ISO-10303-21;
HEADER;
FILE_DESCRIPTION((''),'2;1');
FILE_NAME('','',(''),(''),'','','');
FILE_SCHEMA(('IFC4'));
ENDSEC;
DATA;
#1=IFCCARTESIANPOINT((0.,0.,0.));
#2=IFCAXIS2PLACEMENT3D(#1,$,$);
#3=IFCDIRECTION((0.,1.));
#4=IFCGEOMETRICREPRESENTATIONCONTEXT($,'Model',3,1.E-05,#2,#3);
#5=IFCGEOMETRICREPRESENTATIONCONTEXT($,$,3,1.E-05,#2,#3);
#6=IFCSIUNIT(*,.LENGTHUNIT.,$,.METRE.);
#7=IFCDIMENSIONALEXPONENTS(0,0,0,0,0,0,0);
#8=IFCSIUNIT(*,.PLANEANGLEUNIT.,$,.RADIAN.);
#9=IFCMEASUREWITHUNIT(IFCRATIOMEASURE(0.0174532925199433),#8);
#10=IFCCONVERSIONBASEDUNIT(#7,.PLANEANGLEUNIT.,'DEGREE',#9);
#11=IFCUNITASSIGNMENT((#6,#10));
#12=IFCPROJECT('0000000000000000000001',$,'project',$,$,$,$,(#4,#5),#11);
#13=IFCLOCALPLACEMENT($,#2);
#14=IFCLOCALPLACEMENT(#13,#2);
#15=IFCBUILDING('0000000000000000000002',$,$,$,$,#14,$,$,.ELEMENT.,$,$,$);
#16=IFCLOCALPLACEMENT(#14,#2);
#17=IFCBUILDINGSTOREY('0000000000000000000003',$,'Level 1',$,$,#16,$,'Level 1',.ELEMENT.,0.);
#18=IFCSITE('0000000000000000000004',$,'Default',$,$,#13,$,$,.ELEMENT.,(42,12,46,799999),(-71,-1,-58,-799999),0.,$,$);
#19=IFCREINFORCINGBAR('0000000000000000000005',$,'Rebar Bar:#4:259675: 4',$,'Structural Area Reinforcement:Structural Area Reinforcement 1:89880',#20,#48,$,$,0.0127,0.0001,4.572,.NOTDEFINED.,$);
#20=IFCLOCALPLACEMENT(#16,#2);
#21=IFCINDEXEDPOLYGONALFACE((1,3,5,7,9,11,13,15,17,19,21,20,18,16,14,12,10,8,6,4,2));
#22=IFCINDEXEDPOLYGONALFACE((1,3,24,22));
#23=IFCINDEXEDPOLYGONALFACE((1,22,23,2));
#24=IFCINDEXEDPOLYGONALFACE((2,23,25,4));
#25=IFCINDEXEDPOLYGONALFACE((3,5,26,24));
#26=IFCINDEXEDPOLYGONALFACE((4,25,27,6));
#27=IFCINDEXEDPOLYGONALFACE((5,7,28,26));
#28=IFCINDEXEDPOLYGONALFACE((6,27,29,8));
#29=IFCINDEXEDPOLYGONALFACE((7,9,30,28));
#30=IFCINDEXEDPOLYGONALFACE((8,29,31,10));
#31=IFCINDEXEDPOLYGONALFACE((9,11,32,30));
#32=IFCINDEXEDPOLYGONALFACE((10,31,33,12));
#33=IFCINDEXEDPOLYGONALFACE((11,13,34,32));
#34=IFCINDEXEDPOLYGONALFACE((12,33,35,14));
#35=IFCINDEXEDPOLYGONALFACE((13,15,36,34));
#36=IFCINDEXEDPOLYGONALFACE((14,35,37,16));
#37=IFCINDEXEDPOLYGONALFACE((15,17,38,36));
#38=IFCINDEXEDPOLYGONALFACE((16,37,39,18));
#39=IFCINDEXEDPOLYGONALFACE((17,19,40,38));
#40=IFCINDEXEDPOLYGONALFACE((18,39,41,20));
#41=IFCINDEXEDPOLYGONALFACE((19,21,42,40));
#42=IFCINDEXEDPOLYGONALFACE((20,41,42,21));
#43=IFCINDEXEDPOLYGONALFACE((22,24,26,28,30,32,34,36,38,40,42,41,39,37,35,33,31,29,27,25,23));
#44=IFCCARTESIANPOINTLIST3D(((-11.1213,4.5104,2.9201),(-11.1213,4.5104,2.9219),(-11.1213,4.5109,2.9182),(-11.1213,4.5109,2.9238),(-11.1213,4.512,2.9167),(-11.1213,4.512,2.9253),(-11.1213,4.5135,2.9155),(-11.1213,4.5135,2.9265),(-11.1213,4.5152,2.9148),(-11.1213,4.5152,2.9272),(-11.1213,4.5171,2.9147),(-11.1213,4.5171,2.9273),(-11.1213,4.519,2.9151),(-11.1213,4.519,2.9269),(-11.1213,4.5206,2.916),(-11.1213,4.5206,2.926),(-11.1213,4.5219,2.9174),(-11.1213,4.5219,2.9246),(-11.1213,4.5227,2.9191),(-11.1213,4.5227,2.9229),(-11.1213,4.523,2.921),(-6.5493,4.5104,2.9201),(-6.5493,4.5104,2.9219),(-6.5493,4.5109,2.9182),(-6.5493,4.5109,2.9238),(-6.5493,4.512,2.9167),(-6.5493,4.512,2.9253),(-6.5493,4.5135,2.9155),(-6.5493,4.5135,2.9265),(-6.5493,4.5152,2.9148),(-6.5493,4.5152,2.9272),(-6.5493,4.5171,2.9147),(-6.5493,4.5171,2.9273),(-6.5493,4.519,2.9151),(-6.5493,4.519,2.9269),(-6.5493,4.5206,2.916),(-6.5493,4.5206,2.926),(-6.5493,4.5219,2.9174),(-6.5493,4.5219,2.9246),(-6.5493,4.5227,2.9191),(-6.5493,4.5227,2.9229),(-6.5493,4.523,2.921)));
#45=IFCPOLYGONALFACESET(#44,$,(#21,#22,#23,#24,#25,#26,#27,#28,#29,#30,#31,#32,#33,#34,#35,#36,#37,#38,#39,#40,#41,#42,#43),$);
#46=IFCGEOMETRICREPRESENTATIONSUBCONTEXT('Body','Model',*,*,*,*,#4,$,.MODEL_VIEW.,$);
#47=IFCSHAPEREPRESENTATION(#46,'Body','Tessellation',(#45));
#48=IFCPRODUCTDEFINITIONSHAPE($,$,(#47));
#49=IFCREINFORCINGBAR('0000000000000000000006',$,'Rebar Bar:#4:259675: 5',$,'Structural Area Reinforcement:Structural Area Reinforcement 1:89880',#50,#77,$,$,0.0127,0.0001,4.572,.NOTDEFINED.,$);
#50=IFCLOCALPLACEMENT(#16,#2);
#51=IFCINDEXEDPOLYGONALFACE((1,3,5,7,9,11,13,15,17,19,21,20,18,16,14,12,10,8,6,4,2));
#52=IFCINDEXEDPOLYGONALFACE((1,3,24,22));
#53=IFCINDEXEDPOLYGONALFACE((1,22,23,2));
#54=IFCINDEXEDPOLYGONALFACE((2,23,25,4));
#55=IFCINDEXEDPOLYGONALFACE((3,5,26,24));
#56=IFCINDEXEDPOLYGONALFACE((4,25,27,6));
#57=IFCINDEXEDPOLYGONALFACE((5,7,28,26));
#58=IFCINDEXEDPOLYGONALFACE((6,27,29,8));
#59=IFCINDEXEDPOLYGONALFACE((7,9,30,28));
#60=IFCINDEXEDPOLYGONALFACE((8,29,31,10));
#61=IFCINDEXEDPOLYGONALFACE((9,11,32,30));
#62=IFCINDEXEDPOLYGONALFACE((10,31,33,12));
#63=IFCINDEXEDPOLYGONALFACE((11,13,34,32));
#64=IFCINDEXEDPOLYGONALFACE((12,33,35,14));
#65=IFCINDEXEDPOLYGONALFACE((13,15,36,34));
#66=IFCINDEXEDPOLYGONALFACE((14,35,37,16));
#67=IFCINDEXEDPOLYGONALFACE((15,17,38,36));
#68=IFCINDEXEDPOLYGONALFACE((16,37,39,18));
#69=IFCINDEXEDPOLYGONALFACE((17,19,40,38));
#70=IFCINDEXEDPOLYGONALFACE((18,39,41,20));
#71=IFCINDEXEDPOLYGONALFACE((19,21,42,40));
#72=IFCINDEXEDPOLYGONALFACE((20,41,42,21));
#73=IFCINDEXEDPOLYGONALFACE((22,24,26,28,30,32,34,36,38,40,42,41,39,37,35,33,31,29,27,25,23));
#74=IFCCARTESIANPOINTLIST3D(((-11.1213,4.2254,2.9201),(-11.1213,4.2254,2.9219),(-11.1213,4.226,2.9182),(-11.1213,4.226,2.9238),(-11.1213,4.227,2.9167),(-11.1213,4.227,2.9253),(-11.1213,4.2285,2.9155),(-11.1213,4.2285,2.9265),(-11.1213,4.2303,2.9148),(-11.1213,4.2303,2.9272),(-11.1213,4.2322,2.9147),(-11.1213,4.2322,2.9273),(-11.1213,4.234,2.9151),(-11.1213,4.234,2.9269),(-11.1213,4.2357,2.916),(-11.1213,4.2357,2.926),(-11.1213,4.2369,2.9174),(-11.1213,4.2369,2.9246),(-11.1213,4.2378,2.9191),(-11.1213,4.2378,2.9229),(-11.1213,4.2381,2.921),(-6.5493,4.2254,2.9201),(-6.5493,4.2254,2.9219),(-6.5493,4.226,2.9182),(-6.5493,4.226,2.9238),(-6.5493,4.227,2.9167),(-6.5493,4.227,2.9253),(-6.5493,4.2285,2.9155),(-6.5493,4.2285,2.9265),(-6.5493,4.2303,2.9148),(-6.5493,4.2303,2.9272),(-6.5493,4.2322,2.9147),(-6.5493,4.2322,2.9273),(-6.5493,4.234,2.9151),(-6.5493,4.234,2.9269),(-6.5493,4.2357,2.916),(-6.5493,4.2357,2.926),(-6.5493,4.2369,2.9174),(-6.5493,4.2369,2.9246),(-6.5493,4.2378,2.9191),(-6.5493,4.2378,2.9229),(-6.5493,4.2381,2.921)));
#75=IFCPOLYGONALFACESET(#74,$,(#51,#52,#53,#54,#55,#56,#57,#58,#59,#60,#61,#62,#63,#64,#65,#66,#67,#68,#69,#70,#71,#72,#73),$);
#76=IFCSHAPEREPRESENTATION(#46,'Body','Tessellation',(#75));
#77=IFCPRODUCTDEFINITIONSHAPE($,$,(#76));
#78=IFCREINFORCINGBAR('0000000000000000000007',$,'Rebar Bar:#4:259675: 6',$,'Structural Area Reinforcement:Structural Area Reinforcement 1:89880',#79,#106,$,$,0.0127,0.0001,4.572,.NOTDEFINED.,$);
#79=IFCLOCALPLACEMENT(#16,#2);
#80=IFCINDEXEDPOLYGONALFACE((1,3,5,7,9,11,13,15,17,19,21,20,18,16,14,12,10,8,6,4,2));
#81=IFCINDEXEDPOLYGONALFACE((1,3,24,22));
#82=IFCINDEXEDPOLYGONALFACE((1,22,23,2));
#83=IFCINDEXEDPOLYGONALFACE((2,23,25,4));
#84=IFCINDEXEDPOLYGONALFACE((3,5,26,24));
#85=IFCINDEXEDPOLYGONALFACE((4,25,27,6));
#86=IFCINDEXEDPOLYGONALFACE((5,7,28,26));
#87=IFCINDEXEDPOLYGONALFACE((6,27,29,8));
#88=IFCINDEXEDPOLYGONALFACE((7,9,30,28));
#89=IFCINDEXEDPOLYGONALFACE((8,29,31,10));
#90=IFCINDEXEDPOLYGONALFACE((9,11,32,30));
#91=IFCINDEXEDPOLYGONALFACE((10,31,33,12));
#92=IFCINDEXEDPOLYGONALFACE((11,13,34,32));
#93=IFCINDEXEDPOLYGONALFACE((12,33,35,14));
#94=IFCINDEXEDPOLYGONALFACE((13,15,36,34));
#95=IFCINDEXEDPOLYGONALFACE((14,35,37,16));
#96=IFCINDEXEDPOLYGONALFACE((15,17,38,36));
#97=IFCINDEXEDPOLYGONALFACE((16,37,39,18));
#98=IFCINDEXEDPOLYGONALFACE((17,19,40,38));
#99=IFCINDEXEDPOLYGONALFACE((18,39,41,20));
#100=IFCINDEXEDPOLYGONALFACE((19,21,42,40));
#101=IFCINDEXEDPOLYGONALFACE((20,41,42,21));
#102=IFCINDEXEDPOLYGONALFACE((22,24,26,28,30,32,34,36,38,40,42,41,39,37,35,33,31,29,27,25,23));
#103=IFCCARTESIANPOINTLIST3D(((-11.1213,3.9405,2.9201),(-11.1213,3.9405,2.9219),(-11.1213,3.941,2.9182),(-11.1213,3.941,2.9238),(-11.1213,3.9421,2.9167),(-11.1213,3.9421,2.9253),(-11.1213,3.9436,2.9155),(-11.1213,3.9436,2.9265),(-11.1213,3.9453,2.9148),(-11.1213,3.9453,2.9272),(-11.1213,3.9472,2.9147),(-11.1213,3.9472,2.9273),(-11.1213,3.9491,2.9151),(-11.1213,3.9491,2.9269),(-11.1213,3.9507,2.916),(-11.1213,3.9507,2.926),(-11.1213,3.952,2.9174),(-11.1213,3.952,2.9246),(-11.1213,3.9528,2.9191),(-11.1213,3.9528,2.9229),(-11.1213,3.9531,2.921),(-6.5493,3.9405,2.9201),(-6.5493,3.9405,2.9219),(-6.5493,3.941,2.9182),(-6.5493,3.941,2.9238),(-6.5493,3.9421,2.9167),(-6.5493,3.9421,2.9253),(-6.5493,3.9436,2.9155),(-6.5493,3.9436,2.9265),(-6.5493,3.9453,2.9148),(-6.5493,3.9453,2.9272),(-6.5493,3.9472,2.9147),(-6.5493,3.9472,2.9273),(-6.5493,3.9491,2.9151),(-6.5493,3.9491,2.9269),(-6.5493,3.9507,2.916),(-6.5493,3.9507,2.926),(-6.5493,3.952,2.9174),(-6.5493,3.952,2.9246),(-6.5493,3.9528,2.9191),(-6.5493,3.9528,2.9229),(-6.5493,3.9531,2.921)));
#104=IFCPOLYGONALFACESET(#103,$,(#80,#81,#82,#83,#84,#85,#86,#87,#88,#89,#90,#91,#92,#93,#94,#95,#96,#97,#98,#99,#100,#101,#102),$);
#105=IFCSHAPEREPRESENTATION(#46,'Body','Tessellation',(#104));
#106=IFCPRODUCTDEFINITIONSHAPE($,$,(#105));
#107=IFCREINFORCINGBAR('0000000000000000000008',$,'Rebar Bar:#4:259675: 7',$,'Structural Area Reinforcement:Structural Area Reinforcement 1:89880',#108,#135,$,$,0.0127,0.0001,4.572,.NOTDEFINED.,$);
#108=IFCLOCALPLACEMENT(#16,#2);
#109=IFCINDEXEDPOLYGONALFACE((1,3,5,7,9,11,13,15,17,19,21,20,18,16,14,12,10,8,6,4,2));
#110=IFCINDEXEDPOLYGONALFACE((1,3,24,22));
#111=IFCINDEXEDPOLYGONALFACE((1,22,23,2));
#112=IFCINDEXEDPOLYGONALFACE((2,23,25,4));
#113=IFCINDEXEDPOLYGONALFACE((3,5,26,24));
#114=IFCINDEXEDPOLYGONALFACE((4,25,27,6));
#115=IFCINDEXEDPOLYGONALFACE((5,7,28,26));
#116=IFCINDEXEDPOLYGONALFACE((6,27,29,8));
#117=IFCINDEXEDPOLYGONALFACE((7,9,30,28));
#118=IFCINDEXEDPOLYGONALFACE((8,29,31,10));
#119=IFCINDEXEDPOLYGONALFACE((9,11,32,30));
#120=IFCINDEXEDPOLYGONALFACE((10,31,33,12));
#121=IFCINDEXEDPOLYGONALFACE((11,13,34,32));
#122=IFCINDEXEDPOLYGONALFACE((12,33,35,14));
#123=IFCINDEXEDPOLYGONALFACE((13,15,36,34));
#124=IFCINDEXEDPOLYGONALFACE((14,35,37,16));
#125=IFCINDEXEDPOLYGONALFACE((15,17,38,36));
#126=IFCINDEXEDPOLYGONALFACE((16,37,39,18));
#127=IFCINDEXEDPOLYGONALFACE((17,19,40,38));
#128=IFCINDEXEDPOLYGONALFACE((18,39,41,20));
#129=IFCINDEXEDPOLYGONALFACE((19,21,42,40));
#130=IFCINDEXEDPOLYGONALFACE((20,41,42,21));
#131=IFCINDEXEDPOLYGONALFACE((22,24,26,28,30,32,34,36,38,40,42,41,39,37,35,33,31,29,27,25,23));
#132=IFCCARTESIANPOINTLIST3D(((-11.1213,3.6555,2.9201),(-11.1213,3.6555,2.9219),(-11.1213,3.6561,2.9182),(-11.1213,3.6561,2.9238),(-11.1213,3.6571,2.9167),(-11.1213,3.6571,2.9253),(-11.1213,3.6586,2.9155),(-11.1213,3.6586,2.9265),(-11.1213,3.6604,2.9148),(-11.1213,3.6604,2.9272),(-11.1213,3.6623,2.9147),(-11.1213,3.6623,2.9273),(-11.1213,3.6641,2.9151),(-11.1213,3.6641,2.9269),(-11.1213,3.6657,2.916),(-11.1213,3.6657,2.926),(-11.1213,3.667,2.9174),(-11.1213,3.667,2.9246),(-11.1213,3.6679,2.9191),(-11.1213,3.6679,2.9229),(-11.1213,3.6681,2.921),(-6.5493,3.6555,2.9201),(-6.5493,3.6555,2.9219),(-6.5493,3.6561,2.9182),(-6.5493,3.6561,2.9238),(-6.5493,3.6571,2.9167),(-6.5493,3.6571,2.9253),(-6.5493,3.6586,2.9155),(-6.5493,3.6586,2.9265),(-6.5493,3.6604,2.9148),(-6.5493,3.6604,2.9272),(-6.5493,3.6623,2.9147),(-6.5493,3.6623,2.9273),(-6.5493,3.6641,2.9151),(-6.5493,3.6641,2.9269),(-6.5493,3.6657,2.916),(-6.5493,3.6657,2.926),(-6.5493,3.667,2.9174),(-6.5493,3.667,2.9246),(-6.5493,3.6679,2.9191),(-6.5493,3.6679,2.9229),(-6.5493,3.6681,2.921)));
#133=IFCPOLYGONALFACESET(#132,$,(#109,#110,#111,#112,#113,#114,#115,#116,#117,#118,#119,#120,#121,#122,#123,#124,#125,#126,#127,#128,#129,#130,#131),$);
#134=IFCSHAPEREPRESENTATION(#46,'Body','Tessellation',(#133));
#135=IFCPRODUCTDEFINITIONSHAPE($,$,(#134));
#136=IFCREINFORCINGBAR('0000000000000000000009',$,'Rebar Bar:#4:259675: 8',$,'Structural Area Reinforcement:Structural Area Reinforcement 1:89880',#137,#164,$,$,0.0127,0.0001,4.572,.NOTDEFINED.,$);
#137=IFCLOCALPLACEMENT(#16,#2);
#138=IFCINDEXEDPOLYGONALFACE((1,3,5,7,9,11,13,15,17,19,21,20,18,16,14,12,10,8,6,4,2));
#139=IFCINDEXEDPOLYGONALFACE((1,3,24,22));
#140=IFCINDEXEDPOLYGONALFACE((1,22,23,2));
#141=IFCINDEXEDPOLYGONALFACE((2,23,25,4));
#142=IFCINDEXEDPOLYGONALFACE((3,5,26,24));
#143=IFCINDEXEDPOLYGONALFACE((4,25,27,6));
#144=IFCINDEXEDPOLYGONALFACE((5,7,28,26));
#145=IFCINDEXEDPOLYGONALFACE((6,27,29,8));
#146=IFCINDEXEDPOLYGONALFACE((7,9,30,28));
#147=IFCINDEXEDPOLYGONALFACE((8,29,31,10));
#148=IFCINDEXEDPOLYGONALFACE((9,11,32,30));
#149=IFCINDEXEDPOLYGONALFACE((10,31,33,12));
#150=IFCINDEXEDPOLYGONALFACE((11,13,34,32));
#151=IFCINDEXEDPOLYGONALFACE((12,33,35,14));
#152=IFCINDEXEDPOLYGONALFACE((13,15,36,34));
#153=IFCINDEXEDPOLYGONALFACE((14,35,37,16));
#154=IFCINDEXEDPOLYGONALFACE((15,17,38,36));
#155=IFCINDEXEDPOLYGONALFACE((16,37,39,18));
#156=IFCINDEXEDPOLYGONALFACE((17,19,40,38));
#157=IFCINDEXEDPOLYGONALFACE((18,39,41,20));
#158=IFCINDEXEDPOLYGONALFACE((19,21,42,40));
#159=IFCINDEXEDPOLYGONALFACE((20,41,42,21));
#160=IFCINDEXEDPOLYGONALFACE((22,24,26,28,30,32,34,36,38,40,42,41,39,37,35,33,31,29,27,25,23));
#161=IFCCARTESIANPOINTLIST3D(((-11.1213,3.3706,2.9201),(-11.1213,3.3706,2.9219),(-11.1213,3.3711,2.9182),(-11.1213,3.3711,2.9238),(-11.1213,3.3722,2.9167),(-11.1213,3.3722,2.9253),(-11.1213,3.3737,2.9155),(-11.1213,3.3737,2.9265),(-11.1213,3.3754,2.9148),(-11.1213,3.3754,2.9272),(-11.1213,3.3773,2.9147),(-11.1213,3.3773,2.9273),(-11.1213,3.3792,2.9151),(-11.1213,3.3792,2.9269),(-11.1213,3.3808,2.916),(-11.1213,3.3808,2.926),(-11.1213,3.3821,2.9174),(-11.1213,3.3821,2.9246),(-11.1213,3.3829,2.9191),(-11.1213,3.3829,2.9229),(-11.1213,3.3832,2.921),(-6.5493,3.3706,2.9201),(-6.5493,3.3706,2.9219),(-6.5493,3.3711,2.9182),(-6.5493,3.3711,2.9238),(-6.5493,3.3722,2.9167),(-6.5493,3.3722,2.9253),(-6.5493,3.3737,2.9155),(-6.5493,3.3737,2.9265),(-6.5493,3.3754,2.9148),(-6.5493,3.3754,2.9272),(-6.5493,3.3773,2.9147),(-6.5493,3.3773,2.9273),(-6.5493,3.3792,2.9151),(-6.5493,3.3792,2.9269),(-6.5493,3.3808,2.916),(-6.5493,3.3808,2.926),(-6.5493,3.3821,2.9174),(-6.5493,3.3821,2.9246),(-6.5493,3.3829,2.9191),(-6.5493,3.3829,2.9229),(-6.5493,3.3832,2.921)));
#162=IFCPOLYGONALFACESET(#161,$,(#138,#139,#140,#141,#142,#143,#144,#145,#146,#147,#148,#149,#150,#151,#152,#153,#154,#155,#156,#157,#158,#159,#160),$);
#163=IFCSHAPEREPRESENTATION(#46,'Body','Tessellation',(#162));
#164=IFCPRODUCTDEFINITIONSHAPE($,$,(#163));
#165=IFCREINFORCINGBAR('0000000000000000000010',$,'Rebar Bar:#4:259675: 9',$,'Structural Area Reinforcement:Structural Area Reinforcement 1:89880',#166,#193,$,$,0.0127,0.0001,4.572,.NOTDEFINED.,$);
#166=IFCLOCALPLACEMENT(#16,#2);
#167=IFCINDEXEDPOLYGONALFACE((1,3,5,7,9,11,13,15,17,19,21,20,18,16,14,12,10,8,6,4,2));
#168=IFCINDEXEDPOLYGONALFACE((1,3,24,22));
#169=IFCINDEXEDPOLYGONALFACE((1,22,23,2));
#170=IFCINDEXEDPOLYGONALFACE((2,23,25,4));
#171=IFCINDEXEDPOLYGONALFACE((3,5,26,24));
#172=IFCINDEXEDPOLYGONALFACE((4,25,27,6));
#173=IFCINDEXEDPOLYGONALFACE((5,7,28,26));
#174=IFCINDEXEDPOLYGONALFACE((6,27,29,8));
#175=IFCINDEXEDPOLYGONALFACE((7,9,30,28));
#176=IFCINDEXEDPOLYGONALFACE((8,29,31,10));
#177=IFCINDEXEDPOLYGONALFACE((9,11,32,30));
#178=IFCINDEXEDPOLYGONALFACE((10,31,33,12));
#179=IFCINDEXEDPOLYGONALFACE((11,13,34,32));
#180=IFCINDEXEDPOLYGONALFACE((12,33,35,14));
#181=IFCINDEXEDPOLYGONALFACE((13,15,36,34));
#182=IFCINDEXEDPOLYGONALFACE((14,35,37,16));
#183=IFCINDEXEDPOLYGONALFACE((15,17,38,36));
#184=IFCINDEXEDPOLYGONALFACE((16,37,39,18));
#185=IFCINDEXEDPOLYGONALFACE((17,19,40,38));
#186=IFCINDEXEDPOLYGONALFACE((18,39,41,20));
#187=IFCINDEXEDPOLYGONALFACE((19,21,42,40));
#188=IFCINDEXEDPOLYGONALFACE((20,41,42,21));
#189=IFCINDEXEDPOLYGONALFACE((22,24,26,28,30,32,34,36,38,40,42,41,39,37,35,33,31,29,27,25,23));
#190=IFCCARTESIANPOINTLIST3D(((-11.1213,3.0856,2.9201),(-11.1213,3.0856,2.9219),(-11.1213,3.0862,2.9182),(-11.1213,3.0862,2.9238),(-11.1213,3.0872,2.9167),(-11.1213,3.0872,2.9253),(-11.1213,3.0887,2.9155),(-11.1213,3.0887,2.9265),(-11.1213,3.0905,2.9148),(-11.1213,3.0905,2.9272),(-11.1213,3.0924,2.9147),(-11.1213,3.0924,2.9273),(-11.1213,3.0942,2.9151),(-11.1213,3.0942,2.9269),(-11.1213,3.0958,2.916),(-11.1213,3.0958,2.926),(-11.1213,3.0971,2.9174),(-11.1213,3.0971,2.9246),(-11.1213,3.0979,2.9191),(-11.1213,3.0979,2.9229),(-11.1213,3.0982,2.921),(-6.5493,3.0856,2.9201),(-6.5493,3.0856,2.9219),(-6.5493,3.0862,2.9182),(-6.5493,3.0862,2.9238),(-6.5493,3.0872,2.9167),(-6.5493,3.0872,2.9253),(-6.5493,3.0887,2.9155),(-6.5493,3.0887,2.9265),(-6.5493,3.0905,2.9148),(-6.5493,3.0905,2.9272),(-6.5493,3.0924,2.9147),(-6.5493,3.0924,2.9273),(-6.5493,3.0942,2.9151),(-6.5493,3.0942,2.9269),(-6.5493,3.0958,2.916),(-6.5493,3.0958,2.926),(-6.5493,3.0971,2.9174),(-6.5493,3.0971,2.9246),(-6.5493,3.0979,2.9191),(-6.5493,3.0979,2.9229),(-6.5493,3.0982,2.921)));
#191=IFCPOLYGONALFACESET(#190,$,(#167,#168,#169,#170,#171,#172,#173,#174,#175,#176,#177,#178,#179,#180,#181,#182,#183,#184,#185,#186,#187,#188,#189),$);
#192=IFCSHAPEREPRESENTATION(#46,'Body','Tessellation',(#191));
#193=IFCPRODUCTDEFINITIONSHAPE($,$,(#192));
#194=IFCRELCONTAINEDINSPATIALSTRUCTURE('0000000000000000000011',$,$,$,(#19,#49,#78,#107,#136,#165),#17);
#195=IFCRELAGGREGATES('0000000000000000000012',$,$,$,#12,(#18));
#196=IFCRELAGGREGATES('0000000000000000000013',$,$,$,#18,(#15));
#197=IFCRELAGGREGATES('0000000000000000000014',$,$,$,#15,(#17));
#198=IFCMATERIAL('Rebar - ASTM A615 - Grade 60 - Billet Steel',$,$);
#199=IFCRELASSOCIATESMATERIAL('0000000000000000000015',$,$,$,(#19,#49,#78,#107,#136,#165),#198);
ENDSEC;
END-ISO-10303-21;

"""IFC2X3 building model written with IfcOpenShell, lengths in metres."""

from ifc_helpers import new_model, entity, si_unit, converted_unit, direction, origin, place, context, subcontext, project, spatial, material, element, save


model = new_model("IFC2X3")

# Units and contexts
model_context = context("Model", 3, precision=1e-05, world=origin(), true_north=direction((0.0, 1.0)))
context_of_model = context(None, 3, precision=1e-05, world=origin(), true_north=direction((0.0, 1.0)))
body_context = subcontext(model_context, "Body", "Model", "MODEL_VIEW")
ifc_project = project(units=[si_unit("LENGTHUNIT", "METRE"), converted_unit("PLANEANGLEUNIT", "DEGREE", entity("IfcRatioMeasure", 0.0174532925199433), si_unit("PLANEANGLEUNIT", "RADIAN"), dimensions=[0, 0, 0, 0, 0, 0, 0])], contexts=[model_context, context_of_model])

# Site, building, storey
site_placement = place(None, origin())
site = spatial("IfcSite", under=ifc_project, at=site_placement, Name="Default", CompositionType="ELEMENT", RefLatitude=(42, 12, 46, 799999), RefLongitude=(-71, -1, -58, -799999), RefElevation=0.0)
building_placement = place(site_placement, origin())
building = spatial("IfcBuilding", under=site, at=building_placement, CompositionType="ELEMENT")
storey_placement = place(building_placement, origin())
storey = spatial("IfcBuildingStorey", under=building, at=storey_placement, Name="Level 1", LongName="Level 1", CompositionType="ELEMENT", Elevation=0.0)

# Reinforcing bars
ifc_material_1 = material(Name="Rebar - ASTM A615 - Grade 60 - Billet Steel")
reinforcing_bar_1_placement = place(storey_placement, origin())
element("IfcReinforcingBar", 1, at=reinforcing_bar_1_placement, inside=storey, material=ifc_material_1, Name="Rebar Bar:#4:259675: 4", ObjectType="Structural Area Reinforcement:Structural Area Reinforcement 1:89880", BarLength=4.572, BarRole="NOTDEFINED", CrossSectionArea=0.0001, NominalDiameter=0.0127, context=body_context, shape_type="AdvancedSweptSolid", body=[
    entity("IfcSweptDiskSolid", entity("IfcCompositeCurve", [entity("IfcCompositeCurveSegment", "CONTINUOUS", True, entity("IfcPolyline", [entity("IfcCartesianPoint", [-11.1213, 4.5167, 2.921]), entity("IfcCartesianPoint", [-6.5493, 4.5167, 2.921])]))], False), 0.0063, None, 0.0, 1.0),
])
reinforcing_bar_2_placement = place(storey_placement, origin())
element("IfcReinforcingBar", 2, at=reinforcing_bar_2_placement, inside=storey, material=ifc_material_1, Name="Rebar Bar:#4:259675: 5", ObjectType="Structural Area Reinforcement:Structural Area Reinforcement 1:89880", BarLength=4.572, BarRole="NOTDEFINED", CrossSectionArea=0.0001, NominalDiameter=0.0127, context=body_context, shape_type="AdvancedSweptSolid", body=[
    entity("IfcSweptDiskSolid", entity("IfcCompositeCurve", [entity("IfcCompositeCurveSegment", "CONTINUOUS", True, entity("IfcPolyline", [entity("IfcCartesianPoint", [-11.1213, 4.2317, 2.921]), entity("IfcCartesianPoint", [-6.5493, 4.2317, 2.921])]))], False), 0.0063, None, 0.0, 1.0),
])
reinforcing_bar_3_placement = place(storey_placement, origin())
element("IfcReinforcingBar", 3, at=reinforcing_bar_3_placement, inside=storey, material=ifc_material_1, Name="Rebar Bar:#4:259675: 6", ObjectType="Structural Area Reinforcement:Structural Area Reinforcement 1:89880", BarLength=4.572, BarRole="NOTDEFINED", CrossSectionArea=0.0001, NominalDiameter=0.0127, context=body_context, shape_type="AdvancedSweptSolid", body=[
    entity("IfcSweptDiskSolid", entity("IfcCompositeCurve", [entity("IfcCompositeCurveSegment", "CONTINUOUS", True, entity("IfcPolyline", [entity("IfcCartesianPoint", [-11.1213, 3.9467, 2.921]), entity("IfcCartesianPoint", [-6.5493, 3.9467, 2.921])]))], False), 0.0063, None, 0.0, 1.0),
])
reinforcing_bar_4_placement = place(storey_placement, origin())
element("IfcReinforcingBar", 4, at=reinforcing_bar_4_placement, inside=storey, material=ifc_material_1, Name="Rebar Bar:#4:259675: 7", ObjectType="Structural Area Reinforcement:Structural Area Reinforcement 1:89880", BarLength=4.572, BarRole="NOTDEFINED", CrossSectionArea=0.0001, NominalDiameter=0.0127, context=body_context, shape_type="AdvancedSweptSolid", body=[
    entity("IfcSweptDiskSolid", entity("IfcCompositeCurve", [entity("IfcCompositeCurveSegment", "CONTINUOUS", True, entity("IfcPolyline", [entity("IfcCartesianPoint", [-11.1213, 3.6618, 2.921]), entity("IfcCartesianPoint", [-6.5493, 3.6618, 2.921])]))], False), 0.0063, None, 0.0, 1.0),
])
reinforcing_bar_5_placement = place(storey_placement, origin())
element("IfcReinforcingBar", 5, at=reinforcing_bar_5_placement, inside=storey, material=ifc_material_1, Name="Rebar Bar:#4:259675: 8", ObjectType="Structural Area Reinforcement:Structural Area Reinforcement 1:89880", BarLength=4.572, BarRole="NOTDEFINED", CrossSectionArea=0.0001, NominalDiameter=0.0127, context=body_context, shape_type="AdvancedSweptSolid", body=[
    entity("IfcSweptDiskSolid", entity("IfcCompositeCurve", [entity("IfcCompositeCurveSegment", "CONTINUOUS", True, entity("IfcPolyline", [entity("IfcCartesianPoint", [-11.1213, 3.3768, 2.921]), entity("IfcCartesianPoint", [-6.5493, 3.3768, 2.921])]))], False), 0.0063, None, 0.0, 1.0),
])
reinforcing_bar_6_placement = place(storey_placement, origin())
element("IfcReinforcingBar", 6, at=reinforcing_bar_6_placement, inside=storey, material=ifc_material_1, Name="Rebar Bar:#4:259675: 9", ObjectType="Structural Area Reinforcement:Structural Area Reinforcement 1:89880", BarLength=4.572, BarRole="NOTDEFINED", CrossSectionArea=0.0001, NominalDiameter=0.0127, context=body_context, shape_type="AdvancedSweptSolid", body=[
    entity("IfcSweptDiskSolid", entity("IfcCompositeCurve", [entity("IfcCompositeCurveSegment", "CONTINUOUS", True, entity("IfcPolyline", [entity("IfcCartesianPoint", [-11.1213, 3.0919, 2.921]), entity("IfcCartesianPoint", [-6.5493, 3.0919, 2.921])]))], False), 0.0063, None, 0.0, 1.0),
])

save(model, "model.ifc")
